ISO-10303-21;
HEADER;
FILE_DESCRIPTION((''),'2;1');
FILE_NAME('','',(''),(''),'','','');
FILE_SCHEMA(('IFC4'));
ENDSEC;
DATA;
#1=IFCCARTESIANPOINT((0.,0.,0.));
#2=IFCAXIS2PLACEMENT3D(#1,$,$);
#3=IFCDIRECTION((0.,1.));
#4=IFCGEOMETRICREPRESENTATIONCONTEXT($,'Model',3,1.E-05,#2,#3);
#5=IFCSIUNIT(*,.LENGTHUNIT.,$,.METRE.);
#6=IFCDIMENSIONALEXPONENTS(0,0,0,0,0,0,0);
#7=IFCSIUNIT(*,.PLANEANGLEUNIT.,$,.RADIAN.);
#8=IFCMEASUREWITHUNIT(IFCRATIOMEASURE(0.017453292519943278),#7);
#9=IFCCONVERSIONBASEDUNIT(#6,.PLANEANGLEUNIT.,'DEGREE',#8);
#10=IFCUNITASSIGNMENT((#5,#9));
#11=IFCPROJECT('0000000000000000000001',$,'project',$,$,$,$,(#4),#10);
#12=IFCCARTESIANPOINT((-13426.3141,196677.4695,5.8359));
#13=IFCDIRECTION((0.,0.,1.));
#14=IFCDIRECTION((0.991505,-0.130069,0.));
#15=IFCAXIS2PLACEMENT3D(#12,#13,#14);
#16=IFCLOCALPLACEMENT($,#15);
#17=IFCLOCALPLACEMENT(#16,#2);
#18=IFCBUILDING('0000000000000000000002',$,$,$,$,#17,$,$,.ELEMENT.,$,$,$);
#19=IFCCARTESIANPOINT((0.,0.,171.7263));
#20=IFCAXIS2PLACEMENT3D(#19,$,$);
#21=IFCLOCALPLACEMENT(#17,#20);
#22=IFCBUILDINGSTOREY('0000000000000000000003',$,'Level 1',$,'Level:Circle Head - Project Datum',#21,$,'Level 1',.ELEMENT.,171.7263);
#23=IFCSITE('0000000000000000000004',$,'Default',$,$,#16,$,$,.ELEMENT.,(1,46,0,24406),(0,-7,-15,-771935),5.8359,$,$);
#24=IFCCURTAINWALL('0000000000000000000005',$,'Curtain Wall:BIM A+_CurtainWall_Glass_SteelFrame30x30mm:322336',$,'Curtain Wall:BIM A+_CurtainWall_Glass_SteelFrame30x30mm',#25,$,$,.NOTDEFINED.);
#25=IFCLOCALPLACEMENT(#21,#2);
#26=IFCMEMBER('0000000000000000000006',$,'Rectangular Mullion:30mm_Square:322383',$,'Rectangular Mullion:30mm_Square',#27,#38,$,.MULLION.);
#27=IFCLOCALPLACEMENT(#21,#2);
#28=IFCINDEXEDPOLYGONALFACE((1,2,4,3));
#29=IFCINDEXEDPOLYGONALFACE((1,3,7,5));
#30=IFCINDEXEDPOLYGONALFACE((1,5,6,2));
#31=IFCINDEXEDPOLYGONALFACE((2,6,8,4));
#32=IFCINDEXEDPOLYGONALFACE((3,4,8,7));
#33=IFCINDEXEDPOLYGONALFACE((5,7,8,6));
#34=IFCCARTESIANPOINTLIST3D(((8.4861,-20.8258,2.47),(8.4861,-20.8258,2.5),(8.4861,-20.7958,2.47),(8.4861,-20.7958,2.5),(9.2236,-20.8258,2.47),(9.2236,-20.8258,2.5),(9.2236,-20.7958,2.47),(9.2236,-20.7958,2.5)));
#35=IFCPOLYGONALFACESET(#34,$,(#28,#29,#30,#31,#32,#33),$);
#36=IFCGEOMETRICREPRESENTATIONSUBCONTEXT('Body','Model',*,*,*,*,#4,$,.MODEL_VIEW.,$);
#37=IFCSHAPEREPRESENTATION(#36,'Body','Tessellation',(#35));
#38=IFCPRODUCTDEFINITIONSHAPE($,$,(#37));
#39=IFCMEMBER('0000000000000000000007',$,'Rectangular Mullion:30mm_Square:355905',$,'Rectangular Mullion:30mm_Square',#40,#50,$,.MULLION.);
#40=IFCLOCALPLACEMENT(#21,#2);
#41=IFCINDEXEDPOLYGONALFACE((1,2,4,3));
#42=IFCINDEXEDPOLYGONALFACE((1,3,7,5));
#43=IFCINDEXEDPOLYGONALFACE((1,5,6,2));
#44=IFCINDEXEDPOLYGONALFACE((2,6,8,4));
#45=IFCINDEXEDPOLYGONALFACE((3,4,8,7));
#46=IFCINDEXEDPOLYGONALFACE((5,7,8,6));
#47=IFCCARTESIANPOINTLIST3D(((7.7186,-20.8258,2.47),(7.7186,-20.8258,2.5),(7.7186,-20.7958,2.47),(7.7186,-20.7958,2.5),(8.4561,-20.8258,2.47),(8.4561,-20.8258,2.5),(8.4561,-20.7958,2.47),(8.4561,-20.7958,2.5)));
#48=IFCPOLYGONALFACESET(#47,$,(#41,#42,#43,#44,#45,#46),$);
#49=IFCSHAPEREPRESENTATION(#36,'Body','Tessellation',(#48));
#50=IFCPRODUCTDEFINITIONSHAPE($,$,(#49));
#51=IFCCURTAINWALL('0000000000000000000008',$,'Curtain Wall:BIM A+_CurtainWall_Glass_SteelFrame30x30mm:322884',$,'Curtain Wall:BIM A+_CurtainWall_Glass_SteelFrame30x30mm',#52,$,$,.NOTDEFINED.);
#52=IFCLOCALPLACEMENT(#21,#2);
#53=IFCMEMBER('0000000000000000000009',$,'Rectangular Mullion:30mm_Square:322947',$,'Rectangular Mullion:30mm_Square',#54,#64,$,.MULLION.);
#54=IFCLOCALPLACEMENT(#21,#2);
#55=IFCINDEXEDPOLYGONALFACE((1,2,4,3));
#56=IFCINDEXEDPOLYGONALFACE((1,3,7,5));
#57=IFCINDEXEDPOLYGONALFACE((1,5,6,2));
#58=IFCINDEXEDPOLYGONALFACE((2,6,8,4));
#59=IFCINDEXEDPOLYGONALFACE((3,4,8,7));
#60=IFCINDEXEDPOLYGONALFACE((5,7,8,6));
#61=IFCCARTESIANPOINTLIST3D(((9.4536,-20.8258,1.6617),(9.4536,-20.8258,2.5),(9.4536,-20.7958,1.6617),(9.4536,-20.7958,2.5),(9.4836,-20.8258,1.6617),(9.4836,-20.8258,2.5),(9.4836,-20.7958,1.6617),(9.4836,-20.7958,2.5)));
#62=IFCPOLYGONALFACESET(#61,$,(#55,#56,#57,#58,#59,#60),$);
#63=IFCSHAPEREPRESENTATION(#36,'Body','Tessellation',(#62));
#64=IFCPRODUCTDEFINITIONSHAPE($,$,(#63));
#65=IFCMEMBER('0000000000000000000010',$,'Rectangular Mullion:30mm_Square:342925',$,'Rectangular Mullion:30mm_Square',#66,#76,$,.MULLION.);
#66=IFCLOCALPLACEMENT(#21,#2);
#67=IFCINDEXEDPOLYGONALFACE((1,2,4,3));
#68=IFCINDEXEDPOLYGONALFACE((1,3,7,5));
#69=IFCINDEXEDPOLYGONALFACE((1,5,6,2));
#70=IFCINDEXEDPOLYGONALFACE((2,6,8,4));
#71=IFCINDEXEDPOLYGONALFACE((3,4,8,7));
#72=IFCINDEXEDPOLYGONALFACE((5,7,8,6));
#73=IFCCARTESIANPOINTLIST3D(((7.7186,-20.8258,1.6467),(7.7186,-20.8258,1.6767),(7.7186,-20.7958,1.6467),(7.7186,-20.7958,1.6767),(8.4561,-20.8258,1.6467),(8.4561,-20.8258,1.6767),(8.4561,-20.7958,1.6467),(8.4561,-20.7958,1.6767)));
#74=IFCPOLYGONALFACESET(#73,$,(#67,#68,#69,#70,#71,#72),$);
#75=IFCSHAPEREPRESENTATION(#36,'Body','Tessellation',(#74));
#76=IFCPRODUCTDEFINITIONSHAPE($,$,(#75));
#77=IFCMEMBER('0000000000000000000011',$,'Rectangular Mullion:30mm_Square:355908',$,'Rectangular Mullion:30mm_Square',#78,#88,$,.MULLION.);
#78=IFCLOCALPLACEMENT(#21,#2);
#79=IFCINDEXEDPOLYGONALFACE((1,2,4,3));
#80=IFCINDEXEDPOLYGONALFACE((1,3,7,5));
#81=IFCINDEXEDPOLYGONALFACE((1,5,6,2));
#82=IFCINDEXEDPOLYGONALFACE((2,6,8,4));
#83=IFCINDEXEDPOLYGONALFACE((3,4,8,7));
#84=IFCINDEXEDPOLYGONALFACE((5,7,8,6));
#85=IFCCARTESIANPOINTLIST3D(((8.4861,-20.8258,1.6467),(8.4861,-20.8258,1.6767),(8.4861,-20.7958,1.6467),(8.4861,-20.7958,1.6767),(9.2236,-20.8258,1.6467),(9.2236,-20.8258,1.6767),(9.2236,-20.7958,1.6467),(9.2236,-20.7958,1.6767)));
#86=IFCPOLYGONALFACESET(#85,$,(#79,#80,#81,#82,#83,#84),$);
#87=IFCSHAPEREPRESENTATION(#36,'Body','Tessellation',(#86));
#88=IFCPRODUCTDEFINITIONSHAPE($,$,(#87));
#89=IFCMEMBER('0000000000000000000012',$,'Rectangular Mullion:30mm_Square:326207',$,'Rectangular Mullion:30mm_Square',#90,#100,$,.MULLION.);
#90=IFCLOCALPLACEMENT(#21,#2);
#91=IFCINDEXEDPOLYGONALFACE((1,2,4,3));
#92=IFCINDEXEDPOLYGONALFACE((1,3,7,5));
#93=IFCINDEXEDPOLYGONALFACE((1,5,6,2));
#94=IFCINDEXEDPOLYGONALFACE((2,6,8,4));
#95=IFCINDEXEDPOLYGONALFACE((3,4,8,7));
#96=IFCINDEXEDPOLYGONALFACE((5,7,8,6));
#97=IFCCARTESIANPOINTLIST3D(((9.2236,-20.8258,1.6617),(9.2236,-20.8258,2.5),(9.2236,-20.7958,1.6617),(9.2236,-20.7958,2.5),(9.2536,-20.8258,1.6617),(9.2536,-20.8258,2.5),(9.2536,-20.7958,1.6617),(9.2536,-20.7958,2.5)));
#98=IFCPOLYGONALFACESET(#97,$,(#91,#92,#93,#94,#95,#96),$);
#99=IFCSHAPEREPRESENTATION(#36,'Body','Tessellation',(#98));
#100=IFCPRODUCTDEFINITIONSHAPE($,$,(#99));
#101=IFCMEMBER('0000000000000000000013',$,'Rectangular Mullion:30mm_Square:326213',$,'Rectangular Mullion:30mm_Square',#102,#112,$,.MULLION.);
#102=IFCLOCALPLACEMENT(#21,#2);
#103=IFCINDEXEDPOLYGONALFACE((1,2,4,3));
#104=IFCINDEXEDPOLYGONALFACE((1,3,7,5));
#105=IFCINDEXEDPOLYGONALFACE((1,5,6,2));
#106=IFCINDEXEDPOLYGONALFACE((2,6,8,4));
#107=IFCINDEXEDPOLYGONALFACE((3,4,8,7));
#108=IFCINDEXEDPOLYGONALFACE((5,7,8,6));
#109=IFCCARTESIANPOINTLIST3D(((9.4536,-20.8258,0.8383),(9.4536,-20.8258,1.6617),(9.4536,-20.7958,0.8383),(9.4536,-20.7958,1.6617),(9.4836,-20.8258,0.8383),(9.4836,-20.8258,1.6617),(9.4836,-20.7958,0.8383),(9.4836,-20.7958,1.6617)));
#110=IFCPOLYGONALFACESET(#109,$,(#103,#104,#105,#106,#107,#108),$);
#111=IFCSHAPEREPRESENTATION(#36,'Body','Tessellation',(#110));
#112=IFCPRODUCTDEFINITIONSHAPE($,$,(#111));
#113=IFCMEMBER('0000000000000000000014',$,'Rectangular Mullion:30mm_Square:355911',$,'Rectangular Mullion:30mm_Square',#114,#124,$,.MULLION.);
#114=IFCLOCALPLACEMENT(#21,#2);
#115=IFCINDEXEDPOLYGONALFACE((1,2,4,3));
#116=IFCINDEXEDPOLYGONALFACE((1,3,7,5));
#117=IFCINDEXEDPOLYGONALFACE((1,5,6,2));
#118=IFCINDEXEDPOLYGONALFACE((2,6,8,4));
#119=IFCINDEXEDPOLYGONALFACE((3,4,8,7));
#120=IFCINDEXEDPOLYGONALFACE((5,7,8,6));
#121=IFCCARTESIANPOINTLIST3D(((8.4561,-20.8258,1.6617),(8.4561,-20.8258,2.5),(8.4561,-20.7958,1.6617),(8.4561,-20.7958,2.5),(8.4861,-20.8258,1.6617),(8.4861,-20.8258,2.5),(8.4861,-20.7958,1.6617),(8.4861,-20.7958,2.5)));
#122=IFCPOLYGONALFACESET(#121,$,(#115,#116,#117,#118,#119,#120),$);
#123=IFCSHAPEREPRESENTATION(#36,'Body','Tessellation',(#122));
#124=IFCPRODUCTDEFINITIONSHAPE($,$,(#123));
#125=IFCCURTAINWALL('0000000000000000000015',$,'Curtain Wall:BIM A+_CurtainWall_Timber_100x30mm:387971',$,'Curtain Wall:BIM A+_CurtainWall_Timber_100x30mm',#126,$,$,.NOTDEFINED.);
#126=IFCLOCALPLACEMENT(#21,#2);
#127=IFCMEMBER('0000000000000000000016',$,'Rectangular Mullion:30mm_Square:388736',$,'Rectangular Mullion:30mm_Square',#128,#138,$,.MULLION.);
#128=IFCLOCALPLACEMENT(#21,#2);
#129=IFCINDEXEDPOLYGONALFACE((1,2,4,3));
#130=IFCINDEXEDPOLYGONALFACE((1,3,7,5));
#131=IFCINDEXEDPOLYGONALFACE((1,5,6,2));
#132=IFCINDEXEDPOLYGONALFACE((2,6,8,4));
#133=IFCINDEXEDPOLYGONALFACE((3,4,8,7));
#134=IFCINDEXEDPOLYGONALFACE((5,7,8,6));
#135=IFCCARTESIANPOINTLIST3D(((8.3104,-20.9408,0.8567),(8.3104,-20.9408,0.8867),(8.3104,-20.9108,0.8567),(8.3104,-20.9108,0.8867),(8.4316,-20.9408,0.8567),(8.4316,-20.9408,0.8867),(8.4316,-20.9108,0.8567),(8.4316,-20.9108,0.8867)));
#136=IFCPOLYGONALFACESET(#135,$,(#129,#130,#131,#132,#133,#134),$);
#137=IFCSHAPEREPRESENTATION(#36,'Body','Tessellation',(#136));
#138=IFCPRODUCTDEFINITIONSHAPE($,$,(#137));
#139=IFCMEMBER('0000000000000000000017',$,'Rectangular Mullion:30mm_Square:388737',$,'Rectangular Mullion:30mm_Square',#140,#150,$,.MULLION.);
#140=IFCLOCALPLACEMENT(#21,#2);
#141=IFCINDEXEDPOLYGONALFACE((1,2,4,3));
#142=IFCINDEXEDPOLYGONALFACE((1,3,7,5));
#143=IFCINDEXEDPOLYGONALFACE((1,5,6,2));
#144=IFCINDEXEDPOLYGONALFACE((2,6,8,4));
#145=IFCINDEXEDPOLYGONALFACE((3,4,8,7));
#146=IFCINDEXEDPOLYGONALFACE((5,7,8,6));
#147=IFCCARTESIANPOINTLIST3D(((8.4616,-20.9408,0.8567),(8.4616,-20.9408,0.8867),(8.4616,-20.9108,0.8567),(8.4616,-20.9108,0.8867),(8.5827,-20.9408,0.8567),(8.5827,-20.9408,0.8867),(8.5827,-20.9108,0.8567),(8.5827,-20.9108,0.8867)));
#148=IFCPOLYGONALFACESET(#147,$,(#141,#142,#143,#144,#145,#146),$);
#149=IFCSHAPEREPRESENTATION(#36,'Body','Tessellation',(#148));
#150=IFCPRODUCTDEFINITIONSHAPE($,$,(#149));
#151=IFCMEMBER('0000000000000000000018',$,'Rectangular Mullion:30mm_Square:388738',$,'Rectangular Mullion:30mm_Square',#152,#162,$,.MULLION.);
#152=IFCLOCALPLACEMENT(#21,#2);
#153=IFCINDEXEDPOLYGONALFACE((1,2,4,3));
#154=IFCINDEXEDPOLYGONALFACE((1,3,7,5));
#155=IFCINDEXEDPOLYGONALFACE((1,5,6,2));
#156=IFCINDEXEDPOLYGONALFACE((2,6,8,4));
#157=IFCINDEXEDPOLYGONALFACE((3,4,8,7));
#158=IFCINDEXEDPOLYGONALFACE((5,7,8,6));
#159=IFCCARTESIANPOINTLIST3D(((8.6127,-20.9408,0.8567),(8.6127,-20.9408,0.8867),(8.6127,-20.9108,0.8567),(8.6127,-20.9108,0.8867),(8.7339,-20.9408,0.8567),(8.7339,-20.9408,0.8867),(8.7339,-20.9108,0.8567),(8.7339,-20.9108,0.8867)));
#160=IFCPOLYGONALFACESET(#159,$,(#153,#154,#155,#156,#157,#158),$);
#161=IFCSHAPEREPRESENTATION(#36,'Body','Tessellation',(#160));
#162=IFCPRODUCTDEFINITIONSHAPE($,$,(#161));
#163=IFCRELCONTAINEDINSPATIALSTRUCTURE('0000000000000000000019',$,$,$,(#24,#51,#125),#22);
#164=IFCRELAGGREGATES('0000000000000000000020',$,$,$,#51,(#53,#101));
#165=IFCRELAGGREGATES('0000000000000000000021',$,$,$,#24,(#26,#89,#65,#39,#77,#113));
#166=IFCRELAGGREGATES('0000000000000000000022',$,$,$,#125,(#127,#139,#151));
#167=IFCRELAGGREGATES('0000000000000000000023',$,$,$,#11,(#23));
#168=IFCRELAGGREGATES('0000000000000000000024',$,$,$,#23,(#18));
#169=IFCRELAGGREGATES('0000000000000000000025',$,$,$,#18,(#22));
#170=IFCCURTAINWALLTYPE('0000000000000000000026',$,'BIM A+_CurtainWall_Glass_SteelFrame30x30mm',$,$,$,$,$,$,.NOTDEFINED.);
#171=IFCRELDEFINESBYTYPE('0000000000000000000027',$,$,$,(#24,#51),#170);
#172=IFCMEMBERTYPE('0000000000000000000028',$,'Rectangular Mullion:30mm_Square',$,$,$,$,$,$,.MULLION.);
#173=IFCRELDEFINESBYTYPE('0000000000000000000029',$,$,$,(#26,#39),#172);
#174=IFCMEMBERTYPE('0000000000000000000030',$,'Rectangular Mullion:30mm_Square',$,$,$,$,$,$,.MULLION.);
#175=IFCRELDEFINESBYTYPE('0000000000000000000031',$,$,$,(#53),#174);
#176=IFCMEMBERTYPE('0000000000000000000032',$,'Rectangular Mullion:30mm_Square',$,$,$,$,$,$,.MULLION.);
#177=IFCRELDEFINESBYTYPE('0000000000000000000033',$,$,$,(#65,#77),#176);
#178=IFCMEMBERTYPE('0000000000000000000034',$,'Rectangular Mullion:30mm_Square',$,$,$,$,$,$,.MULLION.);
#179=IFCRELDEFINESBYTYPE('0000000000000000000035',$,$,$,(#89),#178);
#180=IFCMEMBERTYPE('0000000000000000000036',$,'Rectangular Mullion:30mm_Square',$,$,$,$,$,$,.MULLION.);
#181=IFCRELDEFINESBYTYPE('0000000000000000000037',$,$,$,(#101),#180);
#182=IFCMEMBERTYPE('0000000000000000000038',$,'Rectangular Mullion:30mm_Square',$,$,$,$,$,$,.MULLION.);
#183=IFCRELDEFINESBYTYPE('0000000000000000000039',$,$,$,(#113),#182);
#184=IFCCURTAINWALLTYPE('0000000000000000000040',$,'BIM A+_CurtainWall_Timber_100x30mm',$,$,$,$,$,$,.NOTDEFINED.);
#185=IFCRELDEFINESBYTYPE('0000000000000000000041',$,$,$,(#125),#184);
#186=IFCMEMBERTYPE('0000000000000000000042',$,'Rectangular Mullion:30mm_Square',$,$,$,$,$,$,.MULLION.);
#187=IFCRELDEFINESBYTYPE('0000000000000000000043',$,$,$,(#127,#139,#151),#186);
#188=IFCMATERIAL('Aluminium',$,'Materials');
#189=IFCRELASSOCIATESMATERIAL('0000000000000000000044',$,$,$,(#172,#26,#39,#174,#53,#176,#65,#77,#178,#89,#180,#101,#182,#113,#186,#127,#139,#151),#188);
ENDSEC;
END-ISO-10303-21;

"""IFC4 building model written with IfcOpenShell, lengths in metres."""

from ifc_helpers import new_model, entity, si_unit, converted_unit, direction, frame, origin, place, context, subcontext, project, spatial, indexed_curve, outline, extrude, source, transform, mapped, material, type_object, type_shapes, element, aggregate, save


model = new_model("IFC4")

# Units and contexts
model_context = context("Model", 3, precision=1e-05, world=origin(), true_north=direction((0.0, 1.0)))
body_context = subcontext(model_context, "Body", "Model", "MODEL_VIEW")
ifc_project = project(units=[si_unit("LENGTHUNIT", "METRE"), converted_unit("PLANEANGLEUNIT", "DEGREE", entity("IfcRatioMeasure", 0.017453292519943278), si_unit("PLANEANGLEUNIT", "RADIAN"), dimensions=[0, 0, 0, 0, 0, 0, 0])], contexts=[model_context])

# Site, building, storey
site_placement = place(None, frame((-13426.3141, 196677.4695, 5.8359), z_axis=(0.0, 0.0, 1.0), x_axis=(0.991505, -0.130069, 0.0)))
site = spatial("IfcSite", under=ifc_project, at=site_placement, Name="Default", CompositionType="ELEMENT", RefLatitude=(1, 46, 0, 24406), RefLongitude=(0, -7, -15, -771935), RefElevation=5.8359)
building_placement = place(site_placement, origin())
building = spatial("IfcBuilding", under=site, at=building_placement, CompositionType="ELEMENT")
storey_placement = place(building_placement, frame((0.0, 0.0, 171.7263)))
storey = spatial("IfcBuildingStorey", under=building, at=storey_placement, Name="Level 1", ObjectType="Level:Circle Head - Project Datum", LongName="Level 1", CompositionType="ELEMENT", Elevation=171.7263)

# Curtain wall, members
curtain_wall_type_1 = type_object("IfcCurtainWallType", Name="BIM A+_CurtainWall_Glass_SteelFrame30x30mm", PredefinedType="NOTDEFINED")
curtain_wall_1_placement = place(storey_placement, frame((0.0, 0.0, -171.7263)))
curtain_wall_1 = element("IfcCurtainWall", 1, at=curtain_wall_1_placement, inside=storey, type_object=curtain_wall_type_1, Name="Curtain Wall:BIM A+_CurtainWall_Glass_SteelFrame30x30mm:322336", ObjectType="Curtain Wall:BIM A+_CurtainWall_Glass_SteelFrame30x30mm", PredefinedType="NOTDEFINED")
ifc_material_1 = material(Name="Aluminium", Category="Materials")
member_type_1 = type_object("IfcMemberType", Name="Rectangular Mullion:30mm_Square", PredefinedType="MULLION", material=ifc_material_1)
shared_shape_1 = source(origin(), body_context, "Body", "SweptSolid", [
    extrude(outline(indexed_curve([(-0.015, -0.015), (0.015, -0.015), (0.015, 0.015), (-0.015, 0.015), (-0.015, -0.015)], self_intersect=False)), frame((-0.015, 0.0, -0.7375), z_axis=(0.0, 0.0, 1.0), x_axis=(0.0, -1.0, 0.0)), (0.0, 0.0, 1.0), 0.7375),
])
type_shapes(member_type_1, [shared_shape_1])
member_1_placement = place(curtain_wall_1_placement, frame((9.2236, -20.8108, 174.2263), z_axis=(1.0, 0.0, 0.0), x_axis=(0.0, 0.0, 1.0)))
member_1 = element("IfcMember", 2, at=member_1_placement, type_object=member_type_1, material=ifc_material_1, Name="Rectangular Mullion:30mm_Square:322383", ObjectType="Rectangular Mullion:30mm_Square", PredefinedType="MULLION", context=body_context, shape_type="MappedRepresentation", body=[
    mapped(shared_shape_1, transform((0.0, 0.0, 0.0), scale=1.0)),
])
member_2_placement = place(curtain_wall_1_placement, frame((8.4561, -20.8108, 174.2263), z_axis=(1.0, 0.0, 0.0), x_axis=(0.0, 0.0, 1.0)))
member_2 = element("IfcMember", 3, at=member_2_placement, type_object=member_type_1, material=ifc_material_1, Name="Rectangular Mullion:30mm_Square:355905", ObjectType="Rectangular Mullion:30mm_Square", PredefinedType="MULLION", context=body_context, shape_type="MappedRepresentation", body=[
    mapped(shared_shape_1, transform((0.0, 0.0, 0.0), scale=1.0)),
])

# Curtain wall, member
curtain_wall_2_placement = place(storey_placement, frame((0.0, 0.0, -171.7263)))
curtain_wall_2 = element("IfcCurtainWall", 4, at=curtain_wall_2_placement, inside=storey, type_object=curtain_wall_type_1, Name="Curtain Wall:BIM A+_CurtainWall_Glass_SteelFrame30x30mm:322884", ObjectType="Curtain Wall:BIM A+_CurtainWall_Glass_SteelFrame30x30mm", PredefinedType="NOTDEFINED")
member_type_2 = type_object("IfcMemberType", Name="Rectangular Mullion:30mm_Square", PredefinedType="MULLION", material=ifc_material_1)
shared_shape_2 = source(origin(), body_context, "Body", "SweptSolid", [
    extrude(outline(indexed_curve([(-0.015, -0.015), (0.015, -0.015), (0.015, 0.015), (-0.015, 0.015), (-0.015, -0.015)], self_intersect=False)), frame((-0.015, 0.0, -0.8383), z_axis=(0.0, 0.0, 1.0), x_axis=(0.0, -1.0, 0.0)), (0.0, 0.0, 1.0), 0.8383),
])
type_shapes(member_type_2, [shared_shape_2])
member_3_placement = place(curtain_wall_2_placement, frame((9.4536, -20.8108, 174.2263), z_axis=(0.0, 0.0, 1.0), x_axis=(-1.0, 0.0, 0.0)))
member_3 = element("IfcMember", 5, at=member_3_placement, type_object=member_type_2, material=ifc_material_1, Name="Rectangular Mullion:30mm_Square:322947", ObjectType="Rectangular Mullion:30mm_Square", PredefinedType="MULLION", context=body_context, shape_type="MappedRepresentation", body=[
    mapped(shared_shape_2, transform((0.0, 0.0, 0.0), scale=1.0)),
])

# Members
member_type_3 = type_object("IfcMemberType", Name="Rectangular Mullion:30mm_Square", PredefinedType="MULLION", material=ifc_material_1)
shared_shape_3 = source(origin(), body_context, "Body", "SweptSolid", [
    extrude(outline(indexed_curve([(-0.015, -0.015), (0.015, -0.015), (0.015, 0.015), (-0.015, 0.015), (-0.015, -0.015)], self_intersect=False)), frame((0.0, 0.0, -0.7375), z_axis=(0.0, 0.0, 1.0), x_axis=(0.0, -1.0, 0.0)), (0.0, 0.0, 1.0), 0.7375),
])
type_shapes(member_type_3, [shared_shape_3])
member_4_placement = place(curtain_wall_1_placement, frame((8.4561, -20.8108, 173.3879), z_axis=(1.0, 0.0, 0.0), x_axis=(0.0, 0.0, 1.0)))
member_4 = element("IfcMember", 6, at=member_4_placement, type_object=member_type_3, material=ifc_material_1, Name="Rectangular Mullion:30mm_Square:342925", ObjectType="Rectangular Mullion:30mm_Square", PredefinedType="MULLION", context=body_context, shape_type="MappedRepresentation", body=[
    mapped(shared_shape_3, transform((0.0, 0.0, 0.0), scale=1.0)),
])
member_5_placement = place(curtain_wall_1_placement, frame((9.2236, -20.8108, 173.3879), z_axis=(1.0, 0.0, 0.0), x_axis=(0.0, 0.0, 1.0)))
member_5 = element("IfcMember", 7, at=member_5_placement, type_object=member_type_3, material=ifc_material_1, Name="Rectangular Mullion:30mm_Square:355908", ObjectType="Rectangular Mullion:30mm_Square", PredefinedType="MULLION", context=body_context, shape_type="MappedRepresentation", body=[
    mapped(shared_shape_3, transform((0.0, 0.0, 0.0), scale=1.0)),
])
member_type_4 = type_object("IfcMemberType", Name="Rectangular Mullion:30mm_Square", PredefinedType="MULLION", material=ifc_material_1)
shared_shape_4 = source(origin(), body_context, "Body", "SweptSolid", [
    extrude(outline(indexed_curve([(-0.015, -0.015), (0.015, -0.015), (0.015, 0.015), (-0.015, 0.015), (-0.015, -0.015)], self_intersect=False)), frame((-0.015, 0.0, -0.8383), z_axis=(0.0, 0.0, 1.0), x_axis=(0.0, -1.0, 0.0)), (0.0, 0.0, 1.0), 0.8383),
])
type_shapes(member_type_4, [shared_shape_4])
member_6_placement = place(curtain_wall_1_placement, frame((9.2536, -20.8108, 173.3879), z_axis=(0.0, 0.0, -1.0), x_axis=(1.0, 0.0, 0.0)))
member_6 = element("IfcMember", 8, at=member_6_placement, type_object=member_type_4, material=ifc_material_1, Name="Rectangular Mullion:30mm_Square:326207", ObjectType="Rectangular Mullion:30mm_Square", PredefinedType="MULLION", context=body_context, shape_type="MappedRepresentation", body=[
    mapped(shared_shape_4, transform((0.0, 0.0, 0.0), scale=1.0)),
])
member_type_5 = type_object("IfcMemberType", Name="Rectangular Mullion:30mm_Square", PredefinedType="MULLION", material=ifc_material_1)
shared_shape_5 = source(origin(), body_context, "Body", "SweptSolid", [
    extrude(outline(indexed_curve([(-0.015, -0.015), (0.015, -0.015), (0.015, 0.015), (-0.015, 0.015), (-0.015, -0.015)], self_intersect=False)), frame((-0.015, 0.0, -0.8233), z_axis=(0.0, 0.0, 1.0), x_axis=(0.0, -1.0, 0.0)), (0.0, 0.0, 1.0), 0.8233),
])
type_shapes(member_type_5, [shared_shape_5])
member_7_placement = place(curtain_wall_2_placement, frame((9.4536, -20.8108, 173.3879), z_axis=(0.0, 0.0, 1.0), x_axis=(-1.0, 0.0, 0.0)))
member_7 = element("IfcMember", 9, at=member_7_placement, type_object=member_type_5, material=ifc_material_1, Name="Rectangular Mullion:30mm_Square:326213", ObjectType="Rectangular Mullion:30mm_Square", PredefinedType="MULLION", context=body_context, shape_type="MappedRepresentation", body=[
    mapped(shared_shape_5, transform((0.0, 0.0, 0.0), scale=1.0)),
])
aggregate(curtain_wall_2, [member_3, member_7])
member_type_6 = type_object("IfcMemberType", Name="Rectangular Mullion:30mm_Square", PredefinedType="MULLION", material=ifc_material_1)
shared_shape_6 = source(origin(), body_context, "Body", "SweptSolid", [
    extrude(outline(indexed_curve([(-0.015, -0.015), (0.015, -0.015), (0.015, 0.015), (-0.015, 0.015), (-0.015, -0.015)], self_intersect=False)), frame((0.0, 0.0, -0.8383), z_axis=(0.0, 0.0, 1.0), x_axis=(0.0, -1.0, 0.0)), (0.0, 0.0, 1.0), 0.8383),
])
type_shapes(member_type_6, [shared_shape_6])
member_8_placement = place(curtain_wall_1_placement, frame((8.4711, -20.8108, 173.3879), z_axis=(0.0, 0.0, -1.0), x_axis=(1.0, 0.0, 0.0)))
member_8 = element("IfcMember", 10, at=member_8_placement, type_object=member_type_6, material=ifc_material_1, Name="Rectangular Mullion:30mm_Square:355911", ObjectType="Rectangular Mullion:30mm_Square", PredefinedType="MULLION", context=body_context, shape_type="MappedRepresentation", body=[
    mapped(shared_shape_6, transform((0.0, 0.0, 0.0), scale=1.0)),
])

# Curtain wall, members
curtain_wall_type_2 = type_object("IfcCurtainWallType", Name="BIM A+_CurtainWall_Timber_100x30mm", PredefinedType="NOTDEFINED")
curtain_wall_3_placement = place(storey_placement, frame((0.0, 0.0, -171.7263)))
curtain_wall_3 = element("IfcCurtainWall", 11, at=curtain_wall_3_placement, inside=storey, type_object=curtain_wall_type_2, Name="Curtain Wall:BIM A+_CurtainWall_Timber_100x30mm:387971", ObjectType="Curtain Wall:BIM A+_CurtainWall_Timber_100x30mm", PredefinedType="NOTDEFINED")
member_type_7 = type_object("IfcMemberType", Name="Rectangular Mullion:30mm_Square", PredefinedType="MULLION", material=ifc_material_1)
shared_shape_7 = source(origin(), body_context, "Body", "SweptSolid", [
    extrude(outline(indexed_curve([(-0.015, -0.015), (0.015, -0.015), (0.015, 0.015), (-0.015, 0.015), (-0.015, -0.015)], self_intersect=False)), frame((0.0, 0.0, -0.1212), z_axis=(0.0, 0.0, 1.0), x_axis=(0.0, -1.0, 0.0)), (0.0, 0.0, 1.0), 0.1212),
])
type_shapes(member_type_7, [shared_shape_7])
member_9_placement = place(curtain_wall_3_placement, frame((8.4316, -20.9258, 172.598), z_axis=(1.0, 0.0, 0.0), x_axis=(0.0, 0.0, 1.0)))
member_9 = element("IfcMember", 12, at=member_9_placement, type_object=member_type_7, material=ifc_material_1, Name="Rectangular Mullion:30mm_Square:388736", ObjectType="Rectangular Mullion:30mm_Square", PredefinedType="MULLION", context=body_context, shape_type="MappedRepresentation", body=[
    mapped(shared_shape_7, transform((0.0, 0.0, 0.0), scale=1.0)),
])
member_10_placement = place(curtain_wall_3_placement, frame((8.5827, -20.9258, 172.598), z_axis=(1.0, 0.0, 0.0), x_axis=(0.0, 0.0, 1.0)))
member_10 = element("IfcMember", 13, at=member_10_placement, type_object=member_type_7, material=ifc_material_1, Name="Rectangular Mullion:30mm_Square:388737", ObjectType="Rectangular Mullion:30mm_Square", PredefinedType="MULLION", context=body_context, shape_type="MappedRepresentation", body=[
    mapped(shared_shape_7, transform((0.0, 0.0, 0.0), scale=1.0)),
])
member_11_placement = place(curtain_wall_3_placement, frame((8.7339, -20.9258, 172.598), z_axis=(1.0, 0.0, 0.0), x_axis=(0.0, 0.0, 1.0)))
member_11 = element("IfcMember", 14, at=member_11_placement, type_object=member_type_7, material=ifc_material_1, Name="Rectangular Mullion:30mm_Square:388738", ObjectType="Rectangular Mullion:30mm_Square", PredefinedType="MULLION", context=body_context, shape_type="MappedRepresentation", body=[
    mapped(shared_shape_7, transform((0.0, 0.0, 0.0), scale=1.0)),
])

aggregate(curtain_wall_1, [member_1, member_6, member_4, member_2, member_5, member_8])
aggregate(curtain_wall_3, [member_9, member_10, member_11])

save(model, "model.ifc")
